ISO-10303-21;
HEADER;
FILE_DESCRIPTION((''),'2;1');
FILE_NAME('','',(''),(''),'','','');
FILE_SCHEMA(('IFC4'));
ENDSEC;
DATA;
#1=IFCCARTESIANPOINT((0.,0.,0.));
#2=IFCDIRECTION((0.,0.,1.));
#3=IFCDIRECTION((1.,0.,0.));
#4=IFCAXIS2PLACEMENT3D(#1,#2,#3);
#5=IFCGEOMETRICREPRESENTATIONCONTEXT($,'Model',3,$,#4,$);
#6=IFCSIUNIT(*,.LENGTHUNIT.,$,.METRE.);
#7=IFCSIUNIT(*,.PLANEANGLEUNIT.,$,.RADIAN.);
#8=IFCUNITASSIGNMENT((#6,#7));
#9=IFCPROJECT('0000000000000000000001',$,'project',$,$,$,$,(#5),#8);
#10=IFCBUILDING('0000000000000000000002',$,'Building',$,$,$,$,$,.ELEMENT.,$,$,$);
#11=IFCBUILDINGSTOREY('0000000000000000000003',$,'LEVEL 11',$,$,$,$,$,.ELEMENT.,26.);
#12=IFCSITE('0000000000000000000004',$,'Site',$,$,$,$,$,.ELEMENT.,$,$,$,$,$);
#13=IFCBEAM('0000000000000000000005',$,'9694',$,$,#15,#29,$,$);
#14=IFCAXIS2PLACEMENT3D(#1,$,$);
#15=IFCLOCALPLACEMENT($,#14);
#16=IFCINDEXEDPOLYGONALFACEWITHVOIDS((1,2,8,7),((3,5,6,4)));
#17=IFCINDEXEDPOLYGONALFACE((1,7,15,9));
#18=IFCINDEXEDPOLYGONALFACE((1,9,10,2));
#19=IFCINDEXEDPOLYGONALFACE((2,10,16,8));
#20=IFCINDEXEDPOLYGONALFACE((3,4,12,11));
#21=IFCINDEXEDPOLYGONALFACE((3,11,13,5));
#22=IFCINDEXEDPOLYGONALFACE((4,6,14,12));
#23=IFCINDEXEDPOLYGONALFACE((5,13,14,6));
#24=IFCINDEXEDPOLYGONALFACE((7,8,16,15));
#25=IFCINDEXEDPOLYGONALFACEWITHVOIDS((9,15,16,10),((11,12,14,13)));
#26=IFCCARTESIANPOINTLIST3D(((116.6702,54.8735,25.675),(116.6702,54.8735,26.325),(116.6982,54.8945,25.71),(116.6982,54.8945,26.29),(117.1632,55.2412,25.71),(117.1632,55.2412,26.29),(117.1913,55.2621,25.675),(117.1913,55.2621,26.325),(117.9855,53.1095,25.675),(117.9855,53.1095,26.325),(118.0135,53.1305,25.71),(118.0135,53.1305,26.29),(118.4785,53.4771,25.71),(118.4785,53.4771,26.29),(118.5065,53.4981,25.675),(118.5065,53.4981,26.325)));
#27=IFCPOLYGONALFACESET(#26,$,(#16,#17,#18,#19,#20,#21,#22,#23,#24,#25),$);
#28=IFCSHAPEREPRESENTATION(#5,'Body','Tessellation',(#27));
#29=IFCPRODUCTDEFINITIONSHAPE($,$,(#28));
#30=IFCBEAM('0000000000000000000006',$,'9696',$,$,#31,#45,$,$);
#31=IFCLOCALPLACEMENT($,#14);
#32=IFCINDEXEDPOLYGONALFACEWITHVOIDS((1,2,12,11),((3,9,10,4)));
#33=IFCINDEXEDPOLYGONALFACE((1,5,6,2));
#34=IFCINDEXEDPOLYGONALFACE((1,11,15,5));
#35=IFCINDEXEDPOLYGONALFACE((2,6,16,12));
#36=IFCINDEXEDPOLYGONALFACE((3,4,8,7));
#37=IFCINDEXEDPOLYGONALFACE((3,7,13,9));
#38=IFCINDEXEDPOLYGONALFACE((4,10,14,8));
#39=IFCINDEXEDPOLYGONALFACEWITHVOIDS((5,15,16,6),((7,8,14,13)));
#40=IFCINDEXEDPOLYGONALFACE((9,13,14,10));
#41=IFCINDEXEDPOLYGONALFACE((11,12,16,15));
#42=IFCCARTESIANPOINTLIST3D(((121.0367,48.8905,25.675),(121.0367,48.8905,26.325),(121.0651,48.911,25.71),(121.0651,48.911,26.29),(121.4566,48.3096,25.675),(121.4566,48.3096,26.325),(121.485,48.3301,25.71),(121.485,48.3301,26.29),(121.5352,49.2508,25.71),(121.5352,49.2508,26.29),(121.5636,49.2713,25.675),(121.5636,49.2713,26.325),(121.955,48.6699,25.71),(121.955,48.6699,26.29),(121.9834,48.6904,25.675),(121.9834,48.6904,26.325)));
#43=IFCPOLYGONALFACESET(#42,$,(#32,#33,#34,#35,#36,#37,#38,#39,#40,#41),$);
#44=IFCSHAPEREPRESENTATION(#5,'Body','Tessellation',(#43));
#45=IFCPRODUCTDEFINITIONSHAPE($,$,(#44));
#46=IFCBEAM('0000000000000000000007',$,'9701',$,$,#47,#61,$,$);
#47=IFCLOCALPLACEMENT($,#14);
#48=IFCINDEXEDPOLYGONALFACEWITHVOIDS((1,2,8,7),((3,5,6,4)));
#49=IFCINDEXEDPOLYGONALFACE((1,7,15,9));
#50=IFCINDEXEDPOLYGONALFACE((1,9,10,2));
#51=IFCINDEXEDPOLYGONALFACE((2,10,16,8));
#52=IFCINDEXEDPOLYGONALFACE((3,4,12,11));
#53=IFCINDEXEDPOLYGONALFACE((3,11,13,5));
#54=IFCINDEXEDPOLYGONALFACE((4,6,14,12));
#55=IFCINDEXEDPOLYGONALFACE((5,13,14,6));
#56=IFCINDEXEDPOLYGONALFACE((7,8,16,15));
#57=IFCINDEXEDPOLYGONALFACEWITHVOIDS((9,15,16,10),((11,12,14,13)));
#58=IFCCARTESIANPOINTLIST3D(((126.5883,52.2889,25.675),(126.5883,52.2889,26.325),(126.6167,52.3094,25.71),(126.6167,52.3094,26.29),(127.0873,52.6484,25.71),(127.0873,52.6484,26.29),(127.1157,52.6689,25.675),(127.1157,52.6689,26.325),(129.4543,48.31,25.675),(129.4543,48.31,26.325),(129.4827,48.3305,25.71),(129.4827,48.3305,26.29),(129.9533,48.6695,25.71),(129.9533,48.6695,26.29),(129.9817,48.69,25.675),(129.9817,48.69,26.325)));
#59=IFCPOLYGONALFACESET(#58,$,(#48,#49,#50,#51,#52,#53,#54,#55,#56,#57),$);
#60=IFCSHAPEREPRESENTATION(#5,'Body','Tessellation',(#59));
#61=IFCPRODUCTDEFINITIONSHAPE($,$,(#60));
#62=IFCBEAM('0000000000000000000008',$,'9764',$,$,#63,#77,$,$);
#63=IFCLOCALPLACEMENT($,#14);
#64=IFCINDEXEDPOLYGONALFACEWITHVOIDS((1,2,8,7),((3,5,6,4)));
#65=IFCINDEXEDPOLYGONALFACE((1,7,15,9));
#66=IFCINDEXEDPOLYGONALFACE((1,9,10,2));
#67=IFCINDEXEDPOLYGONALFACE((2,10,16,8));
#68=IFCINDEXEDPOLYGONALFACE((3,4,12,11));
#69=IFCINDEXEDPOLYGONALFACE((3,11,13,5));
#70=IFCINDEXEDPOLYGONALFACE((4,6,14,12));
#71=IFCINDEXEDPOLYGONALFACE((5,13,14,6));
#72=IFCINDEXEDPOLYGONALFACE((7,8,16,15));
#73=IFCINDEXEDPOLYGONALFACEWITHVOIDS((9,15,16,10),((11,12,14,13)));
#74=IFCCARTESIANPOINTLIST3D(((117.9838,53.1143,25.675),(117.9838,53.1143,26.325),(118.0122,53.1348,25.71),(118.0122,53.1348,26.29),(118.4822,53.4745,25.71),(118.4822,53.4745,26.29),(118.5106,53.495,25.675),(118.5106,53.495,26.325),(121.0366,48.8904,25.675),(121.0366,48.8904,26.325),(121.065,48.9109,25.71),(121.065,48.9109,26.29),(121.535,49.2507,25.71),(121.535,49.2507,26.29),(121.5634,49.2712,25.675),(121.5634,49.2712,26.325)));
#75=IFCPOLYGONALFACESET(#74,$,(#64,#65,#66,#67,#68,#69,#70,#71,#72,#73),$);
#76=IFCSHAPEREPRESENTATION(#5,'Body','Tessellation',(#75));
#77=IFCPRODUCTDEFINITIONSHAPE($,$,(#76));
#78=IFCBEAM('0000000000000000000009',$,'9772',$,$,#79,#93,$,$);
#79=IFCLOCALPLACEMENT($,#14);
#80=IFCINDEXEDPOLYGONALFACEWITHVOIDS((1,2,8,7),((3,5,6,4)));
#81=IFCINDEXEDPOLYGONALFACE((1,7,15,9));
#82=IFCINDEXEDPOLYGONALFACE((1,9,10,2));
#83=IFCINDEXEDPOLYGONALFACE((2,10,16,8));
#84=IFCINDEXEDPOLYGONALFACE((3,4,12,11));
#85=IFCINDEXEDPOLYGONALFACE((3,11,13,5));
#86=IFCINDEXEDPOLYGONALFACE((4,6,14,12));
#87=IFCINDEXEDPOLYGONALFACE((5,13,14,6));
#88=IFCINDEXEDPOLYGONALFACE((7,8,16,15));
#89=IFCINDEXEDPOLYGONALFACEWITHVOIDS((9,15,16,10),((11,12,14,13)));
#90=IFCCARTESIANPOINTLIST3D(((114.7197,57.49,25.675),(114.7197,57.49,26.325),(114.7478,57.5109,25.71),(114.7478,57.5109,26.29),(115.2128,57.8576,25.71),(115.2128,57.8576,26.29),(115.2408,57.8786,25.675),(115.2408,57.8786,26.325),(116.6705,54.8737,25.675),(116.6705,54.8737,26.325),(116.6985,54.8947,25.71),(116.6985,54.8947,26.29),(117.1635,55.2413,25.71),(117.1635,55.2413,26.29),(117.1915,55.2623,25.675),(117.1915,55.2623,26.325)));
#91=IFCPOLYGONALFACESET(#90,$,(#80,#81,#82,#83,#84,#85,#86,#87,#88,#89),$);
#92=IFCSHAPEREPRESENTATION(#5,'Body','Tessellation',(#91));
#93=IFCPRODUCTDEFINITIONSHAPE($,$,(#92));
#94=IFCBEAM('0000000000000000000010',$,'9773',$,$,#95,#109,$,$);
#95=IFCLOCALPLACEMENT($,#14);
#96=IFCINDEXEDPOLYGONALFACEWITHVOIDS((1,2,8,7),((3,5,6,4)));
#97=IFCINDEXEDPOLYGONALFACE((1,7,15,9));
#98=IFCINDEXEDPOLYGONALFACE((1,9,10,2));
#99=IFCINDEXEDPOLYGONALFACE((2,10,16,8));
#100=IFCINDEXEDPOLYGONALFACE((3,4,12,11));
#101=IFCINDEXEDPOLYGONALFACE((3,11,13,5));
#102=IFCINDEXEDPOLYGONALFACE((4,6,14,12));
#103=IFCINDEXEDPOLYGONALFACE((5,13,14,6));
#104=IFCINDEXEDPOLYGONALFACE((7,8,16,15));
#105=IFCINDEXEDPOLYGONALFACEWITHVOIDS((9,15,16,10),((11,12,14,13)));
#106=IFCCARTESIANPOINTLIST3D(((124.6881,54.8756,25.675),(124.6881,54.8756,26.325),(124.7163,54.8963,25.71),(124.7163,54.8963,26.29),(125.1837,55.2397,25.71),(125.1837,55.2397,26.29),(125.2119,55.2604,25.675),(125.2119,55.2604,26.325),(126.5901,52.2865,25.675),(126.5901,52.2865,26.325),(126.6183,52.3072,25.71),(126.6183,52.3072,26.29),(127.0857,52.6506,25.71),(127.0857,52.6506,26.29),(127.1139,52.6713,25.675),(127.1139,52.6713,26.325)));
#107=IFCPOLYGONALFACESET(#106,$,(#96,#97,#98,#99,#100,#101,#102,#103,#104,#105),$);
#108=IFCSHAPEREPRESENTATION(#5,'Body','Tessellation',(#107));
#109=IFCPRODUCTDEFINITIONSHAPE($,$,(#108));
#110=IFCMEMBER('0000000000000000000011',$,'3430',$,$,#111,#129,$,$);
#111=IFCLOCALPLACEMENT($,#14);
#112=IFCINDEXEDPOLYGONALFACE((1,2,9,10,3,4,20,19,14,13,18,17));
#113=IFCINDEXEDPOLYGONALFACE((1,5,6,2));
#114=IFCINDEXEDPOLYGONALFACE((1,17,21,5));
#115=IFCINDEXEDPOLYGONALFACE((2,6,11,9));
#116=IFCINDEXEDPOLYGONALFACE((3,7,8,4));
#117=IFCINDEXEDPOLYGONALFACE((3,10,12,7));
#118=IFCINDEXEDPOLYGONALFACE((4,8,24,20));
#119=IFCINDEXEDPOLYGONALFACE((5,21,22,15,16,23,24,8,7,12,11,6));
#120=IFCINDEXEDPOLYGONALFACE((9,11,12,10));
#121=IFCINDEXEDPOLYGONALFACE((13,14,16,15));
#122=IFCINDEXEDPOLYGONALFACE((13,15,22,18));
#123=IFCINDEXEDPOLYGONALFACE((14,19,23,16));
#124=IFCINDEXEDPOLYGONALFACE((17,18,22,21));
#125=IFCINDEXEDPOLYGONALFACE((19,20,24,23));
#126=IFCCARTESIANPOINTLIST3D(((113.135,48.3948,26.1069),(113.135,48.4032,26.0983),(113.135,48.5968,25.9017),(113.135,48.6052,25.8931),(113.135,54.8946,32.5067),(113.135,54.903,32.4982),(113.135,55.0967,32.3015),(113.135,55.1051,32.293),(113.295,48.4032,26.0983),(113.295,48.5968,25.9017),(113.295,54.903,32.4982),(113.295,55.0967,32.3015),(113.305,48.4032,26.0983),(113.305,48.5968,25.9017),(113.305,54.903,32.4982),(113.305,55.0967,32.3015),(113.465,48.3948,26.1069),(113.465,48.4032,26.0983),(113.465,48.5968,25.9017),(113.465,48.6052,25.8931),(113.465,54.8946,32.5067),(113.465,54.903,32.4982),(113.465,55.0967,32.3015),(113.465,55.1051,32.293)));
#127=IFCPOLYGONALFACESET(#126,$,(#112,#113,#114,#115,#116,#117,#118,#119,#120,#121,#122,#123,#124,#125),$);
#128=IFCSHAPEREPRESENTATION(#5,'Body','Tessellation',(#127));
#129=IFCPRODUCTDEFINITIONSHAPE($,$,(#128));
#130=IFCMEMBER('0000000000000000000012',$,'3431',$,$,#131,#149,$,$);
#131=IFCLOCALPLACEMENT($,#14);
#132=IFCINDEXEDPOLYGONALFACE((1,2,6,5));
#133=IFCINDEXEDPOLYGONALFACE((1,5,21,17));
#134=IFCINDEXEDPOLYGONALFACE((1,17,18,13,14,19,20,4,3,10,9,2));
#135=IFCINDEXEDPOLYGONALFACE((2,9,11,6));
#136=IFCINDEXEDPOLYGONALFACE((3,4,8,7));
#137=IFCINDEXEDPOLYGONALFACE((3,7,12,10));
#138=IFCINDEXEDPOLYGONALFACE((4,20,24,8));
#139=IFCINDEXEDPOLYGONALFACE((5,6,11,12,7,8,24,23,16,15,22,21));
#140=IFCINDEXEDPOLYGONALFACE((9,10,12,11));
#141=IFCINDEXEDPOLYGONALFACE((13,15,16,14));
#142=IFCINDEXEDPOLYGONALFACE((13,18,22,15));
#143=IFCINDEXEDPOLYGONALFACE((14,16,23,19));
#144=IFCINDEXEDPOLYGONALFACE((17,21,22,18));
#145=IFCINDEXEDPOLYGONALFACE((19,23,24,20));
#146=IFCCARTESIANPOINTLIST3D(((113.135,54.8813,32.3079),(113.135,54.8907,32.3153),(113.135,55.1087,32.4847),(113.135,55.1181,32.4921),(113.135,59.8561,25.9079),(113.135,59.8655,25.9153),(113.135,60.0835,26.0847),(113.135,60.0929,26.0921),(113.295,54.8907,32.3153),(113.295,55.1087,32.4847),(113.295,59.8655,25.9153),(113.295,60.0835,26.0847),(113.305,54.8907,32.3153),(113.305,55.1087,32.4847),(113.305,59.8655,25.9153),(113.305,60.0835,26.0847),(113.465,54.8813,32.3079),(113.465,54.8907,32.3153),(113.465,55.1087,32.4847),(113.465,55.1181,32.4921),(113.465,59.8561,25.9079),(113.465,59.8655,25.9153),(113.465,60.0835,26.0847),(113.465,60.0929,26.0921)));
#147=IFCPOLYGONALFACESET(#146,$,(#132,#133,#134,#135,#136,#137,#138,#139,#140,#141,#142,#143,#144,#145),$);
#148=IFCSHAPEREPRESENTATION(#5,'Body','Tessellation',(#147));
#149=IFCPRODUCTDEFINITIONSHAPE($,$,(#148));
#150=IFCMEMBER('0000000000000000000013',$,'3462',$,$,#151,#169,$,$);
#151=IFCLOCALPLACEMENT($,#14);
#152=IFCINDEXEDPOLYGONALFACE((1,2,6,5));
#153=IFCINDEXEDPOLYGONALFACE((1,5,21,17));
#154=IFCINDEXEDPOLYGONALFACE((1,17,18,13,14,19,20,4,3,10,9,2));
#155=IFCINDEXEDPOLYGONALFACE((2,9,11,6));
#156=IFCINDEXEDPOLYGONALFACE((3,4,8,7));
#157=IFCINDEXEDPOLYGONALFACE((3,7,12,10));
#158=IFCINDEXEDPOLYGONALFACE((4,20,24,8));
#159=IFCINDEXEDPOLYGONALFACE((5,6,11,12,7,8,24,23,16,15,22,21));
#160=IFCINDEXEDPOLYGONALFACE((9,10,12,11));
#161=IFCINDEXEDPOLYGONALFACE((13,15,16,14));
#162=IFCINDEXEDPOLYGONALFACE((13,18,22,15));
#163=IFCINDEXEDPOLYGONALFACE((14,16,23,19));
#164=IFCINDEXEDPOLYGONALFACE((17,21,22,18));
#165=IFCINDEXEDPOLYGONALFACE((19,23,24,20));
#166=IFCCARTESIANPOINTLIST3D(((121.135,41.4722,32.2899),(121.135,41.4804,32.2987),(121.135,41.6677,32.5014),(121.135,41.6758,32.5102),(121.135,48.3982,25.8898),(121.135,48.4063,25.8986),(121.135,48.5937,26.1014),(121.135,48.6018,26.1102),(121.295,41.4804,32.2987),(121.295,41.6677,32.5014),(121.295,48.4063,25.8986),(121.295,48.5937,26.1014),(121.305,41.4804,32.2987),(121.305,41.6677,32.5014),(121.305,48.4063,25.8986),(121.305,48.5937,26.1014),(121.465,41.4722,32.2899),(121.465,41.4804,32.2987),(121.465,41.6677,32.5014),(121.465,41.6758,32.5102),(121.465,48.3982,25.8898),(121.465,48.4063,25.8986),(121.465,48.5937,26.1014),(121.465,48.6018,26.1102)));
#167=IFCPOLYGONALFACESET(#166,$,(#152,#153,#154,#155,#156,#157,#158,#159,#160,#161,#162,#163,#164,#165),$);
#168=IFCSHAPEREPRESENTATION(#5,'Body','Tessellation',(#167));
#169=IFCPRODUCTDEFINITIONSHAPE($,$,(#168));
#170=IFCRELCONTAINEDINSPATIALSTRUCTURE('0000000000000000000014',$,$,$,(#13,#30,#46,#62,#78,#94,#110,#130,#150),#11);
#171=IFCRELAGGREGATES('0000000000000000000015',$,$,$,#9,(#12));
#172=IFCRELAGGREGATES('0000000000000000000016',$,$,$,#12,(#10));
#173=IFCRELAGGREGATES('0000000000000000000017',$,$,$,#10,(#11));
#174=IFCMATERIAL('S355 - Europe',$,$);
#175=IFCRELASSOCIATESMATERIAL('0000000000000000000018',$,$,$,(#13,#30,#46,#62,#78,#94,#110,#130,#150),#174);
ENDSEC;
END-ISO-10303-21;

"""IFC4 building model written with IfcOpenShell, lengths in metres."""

from ifc_helpers import new_model, si_unit, frame, origin_with_axes, origin_2d_with_axis, place, context, project, spatial, hollow_rectangle, i_section, extrude, material, material_profile, profile_set, profile_usage, element, save


model = new_model("IFC4")

# Units and contexts
model_context = context("Model", 3, world=origin_with_axes())
ifc_project = project(units=[si_unit("LENGTHUNIT", "METRE"), si_unit("PLANEANGLEUNIT", "RADIAN")], contexts=[model_context])

# Site, building, storey
site = spatial("IfcSite", under=ifc_project, Name="Site", CompositionType="ELEMENT")
building = spatial("IfcBuilding", under=site, Name="Building", CompositionType="ELEMENT")
storey = spatial("IfcBuildingStorey", under=building, Name="LEVEL 11", CompositionType="ELEMENT", Elevation=26.0)

# Shared definitions
ifc_material = material(Name="S355 - Europe")

# Beams
ifc_material_profile_1 = material_profile(ifc_material, hollow_rectangle(XDim=0.65, YDim=0.65, WallThickness=0.035, at=origin_2d_with_axis()))
ifc_profile_set_1 = profile_set([ifc_material_profile_1])
ifc_profile_usage_1 = profile_usage(ifc_profile_set_1, cardinal=10)
beam_1_placement = place(None, frame((118.246, 53.3038, 26.0), z_axis=(-0.597746, 0.801686, 0.0), x_axis=(-0.802364, -0.596835, 0.0)))
element("IfcBeam", 1, at=beam_1_placement, inside=storey, material=ifc_profile_usage_1, Name="9694", context=model_context, shape_type="SweptSolid", body=[
    extrude(hollow_rectangle(XDim=0.65, YDim=0.65, WallThickness=0.035, at=origin_2d_with_axis()), origin_with_axes(), (0.0, 0.0, 1.0), 2.2004),
])
ifc_material_profile_2 = material_profile(ifc_material, hollow_rectangle(XDim=0.65, YDim=0.65, WallThickness=0.035, at=origin_2d_with_axis()))
ifc_profile_set_2 = profile_set([ifc_material_profile_2])
ifc_profile_usage_2 = profile_usage(ifc_profile_set_2, cardinal=10)
beam_2_placement = place(None, frame((121.72, 48.5, 26.0), z_axis=(-0.585773, 0.810475, 0.0), x_axis=(-0.810441, -0.585821, 0.0)))
element("IfcBeam", 2, at=beam_2_placement, inside=storey, material=ifc_profile_usage_2, Name="9696", context=model_context, shape_type="SweptSolid", body=[
    extrude(hollow_rectangle(XDim=0.65, YDim=0.65, WallThickness=0.035, at=origin_2d_with_axis()), origin_with_axes(), (0.0, 0.0, 1.0), 0.7167),
])
ifc_material_profile_3 = material_profile(ifc_material, hollow_rectangle(XDim=0.65, YDim=0.65, WallThickness=0.035, at=origin_2d_with_axis()))
ifc_profile_set_3 = profile_set([ifc_material_profile_3])
ifc_profile_usage_3 = profile_usage(ifc_profile_set_3, cardinal=10)
beam_3_placement = place(None, frame((126.852, 52.4789, 26.0), z_axis=(0.584465, -0.811419, 0.0), x_axis=(0.811419, 0.584465, 0.0)))
element("IfcBeam", 3, at=beam_3_placement, inside=storey, material=ifc_profile_usage_3, Name="9701", context=model_context, shape_type="SweptSolid", body=[
    extrude(hollow_rectangle(XDim=0.65, YDim=0.65, WallThickness=0.035, at=origin_2d_with_axis()), origin_with_axes(), (0.0, 0.0, 1.0), 4.9036),
])
ifc_material_profile_4 = material_profile(ifc_material, hollow_rectangle(XDim=0.65, YDim=0.65, WallThickness=0.035, at=origin_2d_with_axis()))
ifc_profile_set_4 = profile_set([ifc_material_profile_4])
ifc_profile_usage_4 = profile_usage(ifc_profile_set_4, cardinal=10)
beam_4_placement = place(None, frame((121.3, 49.0808, 26.0), z_axis=(-0.585773, 0.810475, 0.0), x_axis=(-0.810441, -0.585821, 0.0)))
element("IfcBeam", 4, at=beam_4_placement, inside=storey, material=ifc_profile_usage_4, Name="9764", context=model_context, shape_type="SweptSolid", body=[
    extrude(hollow_rectangle(XDim=0.65, YDim=0.65, WallThickness=0.035, at=origin_2d_with_axis()), origin_with_axes(), (0.0, 0.0, 1.0), 5.2116),
])
ifc_material_profile_5 = material_profile(ifc_material, hollow_rectangle(XDim=0.65, YDim=0.65, WallThickness=0.035, at=origin_2d_with_axis()))
ifc_profile_set_5 = profile_set([ifc_material_profile_5])
ifc_profile_usage_5 = profile_usage(ifc_profile_set_5, cardinal=10)
beam_5_placement = place(None, frame((116.931, 55.068, 26.0), z_axis=(-0.597746, 0.801686, 0.0), x_axis=(-0.802364, -0.596835, 0.0)))
element("IfcBeam", 5, at=beam_5_placement, inside=storey, material=ifc_profile_usage_5, Name="9772", context=model_context, shape_type="SweptSolid", body=[
    extrude(hollow_rectangle(XDim=0.65, YDim=0.65, WallThickness=0.035, at=origin_2d_with_axis()), origin_with_axes(), (0.0, 0.0, 1.0), 3.2635),
])
ifc_material_profile_6 = material_profile(ifc_material, hollow_rectangle(XDim=0.65, YDim=0.65, WallThickness=0.035, at=origin_2d_with_axis()))
ifc_profile_set_6 = profile_set([ifc_material_profile_6])
ifc_profile_usage_6 = profile_usage(ifc_profile_set_6, cardinal=10)
beam_6_placement = place(None, frame((124.95, 55.068, 26.0), z_axis=(0.592045, -0.805905, 0.0), x_axis=(0.805798, 0.59219, 0.0)))
element("IfcBeam", 6, at=beam_6_placement, inside=storey, material=ifc_profile_usage_6, Name="9773", context=model_context, shape_type="SweptSolid", body=[
    extrude(hollow_rectangle(XDim=0.65, YDim=0.65, WallThickness=0.035, at=origin_2d_with_axis()), origin_with_axes(), (0.0, 0.0, 1.0), 3.2126),
])

# Members
ifc_material_profile_7 = material_profile(ifc_material, i_section(OverallWidth=0.33, OverallDepth=0.3, WebThickness=0.01, FlangeThickness=0.012, at=origin_2d_with_axis()))
ifc_profile_set_7 = profile_set([ifc_material_profile_7])
ifc_profile_usage_7 = profile_usage(ifc_profile_set_7, cardinal=10)
member_1_placement = place(None, frame((113.3, 48.5, 26.0), z_axis=(0.0, 0.712567, 0.701604), x_axis=(-1.0, 0.0, 0.0)))
element("IfcMember", 7, at=member_1_placement, inside=storey, material=ifc_profile_usage_7, Name="3430", context=model_context, shape_type="SweptSolid", body=[
    extrude(i_section(OverallWidth=0.33, OverallDepth=0.3, WebThickness=0.01, FlangeThickness=0.012, at=origin_2d_with_axis()), origin_with_axes(), (0.0, 0.0, 1.0), 9.1217),
])
ifc_material_profile_8 = material_profile(ifc_material, i_section(OverallWidth=0.33, OverallDepth=0.3, WebThickness=0.01, FlangeThickness=0.012, at=origin_2d_with_axis()))
ifc_profile_set_8 = profile_set([ifc_material_profile_8])
ifc_profile_usage_8 = profile_usage(ifc_profile_set_8, cardinal=10)
member_2_placement = place(None, frame((113.3, 54.9997, 32.4), z_axis=(0.0, 0.613712, -0.78953), x_axis=(-1.0, 0.0, 0.0)))
element("IfcMember", 8, at=member_2_placement, inside=storey, material=ifc_profile_usage_8, Name="3431", context=model_context, shape_type="SweptSolid", body=[
    extrude(i_section(OverallWidth=0.33, OverallDepth=0.3, WebThickness=0.01, FlangeThickness=0.012, at=origin_2d_with_axis()), origin_with_axes(), (0.0, 0.0, 1.0), 8.1061),
])
ifc_material_profile_9 = material_profile(ifc_material, i_section(OverallWidth=0.33, OverallDepth=0.3, WebThickness=0.01, FlangeThickness=0.012, at=origin_2d_with_axis()))
ifc_profile_set_9 = profile_set([ifc_material_profile_9])
ifc_profile_usage_9 = profile_usage(ifc_profile_set_9, cardinal=10)
member_3_placement = place(None, frame((121.3, 48.5, 26.0), z_axis=(0.0, -0.734441, 0.678673), x_axis=(1.0, 0.0, 0.0)))
element("IfcMember", 9, at=member_3_placement, inside=storey, material=ifc_profile_usage_9, Name="3462", context=model_context, shape_type="SweptSolid", body=[
    extrude(i_section(OverallWidth=0.33, OverallDepth=0.3, WebThickness=0.01, FlangeThickness=0.012, at=origin_2d_with_axis()), origin_with_axes(), (0.0, 0.0, 1.0), 9.4302),
])

save(model, "model.ifc")
